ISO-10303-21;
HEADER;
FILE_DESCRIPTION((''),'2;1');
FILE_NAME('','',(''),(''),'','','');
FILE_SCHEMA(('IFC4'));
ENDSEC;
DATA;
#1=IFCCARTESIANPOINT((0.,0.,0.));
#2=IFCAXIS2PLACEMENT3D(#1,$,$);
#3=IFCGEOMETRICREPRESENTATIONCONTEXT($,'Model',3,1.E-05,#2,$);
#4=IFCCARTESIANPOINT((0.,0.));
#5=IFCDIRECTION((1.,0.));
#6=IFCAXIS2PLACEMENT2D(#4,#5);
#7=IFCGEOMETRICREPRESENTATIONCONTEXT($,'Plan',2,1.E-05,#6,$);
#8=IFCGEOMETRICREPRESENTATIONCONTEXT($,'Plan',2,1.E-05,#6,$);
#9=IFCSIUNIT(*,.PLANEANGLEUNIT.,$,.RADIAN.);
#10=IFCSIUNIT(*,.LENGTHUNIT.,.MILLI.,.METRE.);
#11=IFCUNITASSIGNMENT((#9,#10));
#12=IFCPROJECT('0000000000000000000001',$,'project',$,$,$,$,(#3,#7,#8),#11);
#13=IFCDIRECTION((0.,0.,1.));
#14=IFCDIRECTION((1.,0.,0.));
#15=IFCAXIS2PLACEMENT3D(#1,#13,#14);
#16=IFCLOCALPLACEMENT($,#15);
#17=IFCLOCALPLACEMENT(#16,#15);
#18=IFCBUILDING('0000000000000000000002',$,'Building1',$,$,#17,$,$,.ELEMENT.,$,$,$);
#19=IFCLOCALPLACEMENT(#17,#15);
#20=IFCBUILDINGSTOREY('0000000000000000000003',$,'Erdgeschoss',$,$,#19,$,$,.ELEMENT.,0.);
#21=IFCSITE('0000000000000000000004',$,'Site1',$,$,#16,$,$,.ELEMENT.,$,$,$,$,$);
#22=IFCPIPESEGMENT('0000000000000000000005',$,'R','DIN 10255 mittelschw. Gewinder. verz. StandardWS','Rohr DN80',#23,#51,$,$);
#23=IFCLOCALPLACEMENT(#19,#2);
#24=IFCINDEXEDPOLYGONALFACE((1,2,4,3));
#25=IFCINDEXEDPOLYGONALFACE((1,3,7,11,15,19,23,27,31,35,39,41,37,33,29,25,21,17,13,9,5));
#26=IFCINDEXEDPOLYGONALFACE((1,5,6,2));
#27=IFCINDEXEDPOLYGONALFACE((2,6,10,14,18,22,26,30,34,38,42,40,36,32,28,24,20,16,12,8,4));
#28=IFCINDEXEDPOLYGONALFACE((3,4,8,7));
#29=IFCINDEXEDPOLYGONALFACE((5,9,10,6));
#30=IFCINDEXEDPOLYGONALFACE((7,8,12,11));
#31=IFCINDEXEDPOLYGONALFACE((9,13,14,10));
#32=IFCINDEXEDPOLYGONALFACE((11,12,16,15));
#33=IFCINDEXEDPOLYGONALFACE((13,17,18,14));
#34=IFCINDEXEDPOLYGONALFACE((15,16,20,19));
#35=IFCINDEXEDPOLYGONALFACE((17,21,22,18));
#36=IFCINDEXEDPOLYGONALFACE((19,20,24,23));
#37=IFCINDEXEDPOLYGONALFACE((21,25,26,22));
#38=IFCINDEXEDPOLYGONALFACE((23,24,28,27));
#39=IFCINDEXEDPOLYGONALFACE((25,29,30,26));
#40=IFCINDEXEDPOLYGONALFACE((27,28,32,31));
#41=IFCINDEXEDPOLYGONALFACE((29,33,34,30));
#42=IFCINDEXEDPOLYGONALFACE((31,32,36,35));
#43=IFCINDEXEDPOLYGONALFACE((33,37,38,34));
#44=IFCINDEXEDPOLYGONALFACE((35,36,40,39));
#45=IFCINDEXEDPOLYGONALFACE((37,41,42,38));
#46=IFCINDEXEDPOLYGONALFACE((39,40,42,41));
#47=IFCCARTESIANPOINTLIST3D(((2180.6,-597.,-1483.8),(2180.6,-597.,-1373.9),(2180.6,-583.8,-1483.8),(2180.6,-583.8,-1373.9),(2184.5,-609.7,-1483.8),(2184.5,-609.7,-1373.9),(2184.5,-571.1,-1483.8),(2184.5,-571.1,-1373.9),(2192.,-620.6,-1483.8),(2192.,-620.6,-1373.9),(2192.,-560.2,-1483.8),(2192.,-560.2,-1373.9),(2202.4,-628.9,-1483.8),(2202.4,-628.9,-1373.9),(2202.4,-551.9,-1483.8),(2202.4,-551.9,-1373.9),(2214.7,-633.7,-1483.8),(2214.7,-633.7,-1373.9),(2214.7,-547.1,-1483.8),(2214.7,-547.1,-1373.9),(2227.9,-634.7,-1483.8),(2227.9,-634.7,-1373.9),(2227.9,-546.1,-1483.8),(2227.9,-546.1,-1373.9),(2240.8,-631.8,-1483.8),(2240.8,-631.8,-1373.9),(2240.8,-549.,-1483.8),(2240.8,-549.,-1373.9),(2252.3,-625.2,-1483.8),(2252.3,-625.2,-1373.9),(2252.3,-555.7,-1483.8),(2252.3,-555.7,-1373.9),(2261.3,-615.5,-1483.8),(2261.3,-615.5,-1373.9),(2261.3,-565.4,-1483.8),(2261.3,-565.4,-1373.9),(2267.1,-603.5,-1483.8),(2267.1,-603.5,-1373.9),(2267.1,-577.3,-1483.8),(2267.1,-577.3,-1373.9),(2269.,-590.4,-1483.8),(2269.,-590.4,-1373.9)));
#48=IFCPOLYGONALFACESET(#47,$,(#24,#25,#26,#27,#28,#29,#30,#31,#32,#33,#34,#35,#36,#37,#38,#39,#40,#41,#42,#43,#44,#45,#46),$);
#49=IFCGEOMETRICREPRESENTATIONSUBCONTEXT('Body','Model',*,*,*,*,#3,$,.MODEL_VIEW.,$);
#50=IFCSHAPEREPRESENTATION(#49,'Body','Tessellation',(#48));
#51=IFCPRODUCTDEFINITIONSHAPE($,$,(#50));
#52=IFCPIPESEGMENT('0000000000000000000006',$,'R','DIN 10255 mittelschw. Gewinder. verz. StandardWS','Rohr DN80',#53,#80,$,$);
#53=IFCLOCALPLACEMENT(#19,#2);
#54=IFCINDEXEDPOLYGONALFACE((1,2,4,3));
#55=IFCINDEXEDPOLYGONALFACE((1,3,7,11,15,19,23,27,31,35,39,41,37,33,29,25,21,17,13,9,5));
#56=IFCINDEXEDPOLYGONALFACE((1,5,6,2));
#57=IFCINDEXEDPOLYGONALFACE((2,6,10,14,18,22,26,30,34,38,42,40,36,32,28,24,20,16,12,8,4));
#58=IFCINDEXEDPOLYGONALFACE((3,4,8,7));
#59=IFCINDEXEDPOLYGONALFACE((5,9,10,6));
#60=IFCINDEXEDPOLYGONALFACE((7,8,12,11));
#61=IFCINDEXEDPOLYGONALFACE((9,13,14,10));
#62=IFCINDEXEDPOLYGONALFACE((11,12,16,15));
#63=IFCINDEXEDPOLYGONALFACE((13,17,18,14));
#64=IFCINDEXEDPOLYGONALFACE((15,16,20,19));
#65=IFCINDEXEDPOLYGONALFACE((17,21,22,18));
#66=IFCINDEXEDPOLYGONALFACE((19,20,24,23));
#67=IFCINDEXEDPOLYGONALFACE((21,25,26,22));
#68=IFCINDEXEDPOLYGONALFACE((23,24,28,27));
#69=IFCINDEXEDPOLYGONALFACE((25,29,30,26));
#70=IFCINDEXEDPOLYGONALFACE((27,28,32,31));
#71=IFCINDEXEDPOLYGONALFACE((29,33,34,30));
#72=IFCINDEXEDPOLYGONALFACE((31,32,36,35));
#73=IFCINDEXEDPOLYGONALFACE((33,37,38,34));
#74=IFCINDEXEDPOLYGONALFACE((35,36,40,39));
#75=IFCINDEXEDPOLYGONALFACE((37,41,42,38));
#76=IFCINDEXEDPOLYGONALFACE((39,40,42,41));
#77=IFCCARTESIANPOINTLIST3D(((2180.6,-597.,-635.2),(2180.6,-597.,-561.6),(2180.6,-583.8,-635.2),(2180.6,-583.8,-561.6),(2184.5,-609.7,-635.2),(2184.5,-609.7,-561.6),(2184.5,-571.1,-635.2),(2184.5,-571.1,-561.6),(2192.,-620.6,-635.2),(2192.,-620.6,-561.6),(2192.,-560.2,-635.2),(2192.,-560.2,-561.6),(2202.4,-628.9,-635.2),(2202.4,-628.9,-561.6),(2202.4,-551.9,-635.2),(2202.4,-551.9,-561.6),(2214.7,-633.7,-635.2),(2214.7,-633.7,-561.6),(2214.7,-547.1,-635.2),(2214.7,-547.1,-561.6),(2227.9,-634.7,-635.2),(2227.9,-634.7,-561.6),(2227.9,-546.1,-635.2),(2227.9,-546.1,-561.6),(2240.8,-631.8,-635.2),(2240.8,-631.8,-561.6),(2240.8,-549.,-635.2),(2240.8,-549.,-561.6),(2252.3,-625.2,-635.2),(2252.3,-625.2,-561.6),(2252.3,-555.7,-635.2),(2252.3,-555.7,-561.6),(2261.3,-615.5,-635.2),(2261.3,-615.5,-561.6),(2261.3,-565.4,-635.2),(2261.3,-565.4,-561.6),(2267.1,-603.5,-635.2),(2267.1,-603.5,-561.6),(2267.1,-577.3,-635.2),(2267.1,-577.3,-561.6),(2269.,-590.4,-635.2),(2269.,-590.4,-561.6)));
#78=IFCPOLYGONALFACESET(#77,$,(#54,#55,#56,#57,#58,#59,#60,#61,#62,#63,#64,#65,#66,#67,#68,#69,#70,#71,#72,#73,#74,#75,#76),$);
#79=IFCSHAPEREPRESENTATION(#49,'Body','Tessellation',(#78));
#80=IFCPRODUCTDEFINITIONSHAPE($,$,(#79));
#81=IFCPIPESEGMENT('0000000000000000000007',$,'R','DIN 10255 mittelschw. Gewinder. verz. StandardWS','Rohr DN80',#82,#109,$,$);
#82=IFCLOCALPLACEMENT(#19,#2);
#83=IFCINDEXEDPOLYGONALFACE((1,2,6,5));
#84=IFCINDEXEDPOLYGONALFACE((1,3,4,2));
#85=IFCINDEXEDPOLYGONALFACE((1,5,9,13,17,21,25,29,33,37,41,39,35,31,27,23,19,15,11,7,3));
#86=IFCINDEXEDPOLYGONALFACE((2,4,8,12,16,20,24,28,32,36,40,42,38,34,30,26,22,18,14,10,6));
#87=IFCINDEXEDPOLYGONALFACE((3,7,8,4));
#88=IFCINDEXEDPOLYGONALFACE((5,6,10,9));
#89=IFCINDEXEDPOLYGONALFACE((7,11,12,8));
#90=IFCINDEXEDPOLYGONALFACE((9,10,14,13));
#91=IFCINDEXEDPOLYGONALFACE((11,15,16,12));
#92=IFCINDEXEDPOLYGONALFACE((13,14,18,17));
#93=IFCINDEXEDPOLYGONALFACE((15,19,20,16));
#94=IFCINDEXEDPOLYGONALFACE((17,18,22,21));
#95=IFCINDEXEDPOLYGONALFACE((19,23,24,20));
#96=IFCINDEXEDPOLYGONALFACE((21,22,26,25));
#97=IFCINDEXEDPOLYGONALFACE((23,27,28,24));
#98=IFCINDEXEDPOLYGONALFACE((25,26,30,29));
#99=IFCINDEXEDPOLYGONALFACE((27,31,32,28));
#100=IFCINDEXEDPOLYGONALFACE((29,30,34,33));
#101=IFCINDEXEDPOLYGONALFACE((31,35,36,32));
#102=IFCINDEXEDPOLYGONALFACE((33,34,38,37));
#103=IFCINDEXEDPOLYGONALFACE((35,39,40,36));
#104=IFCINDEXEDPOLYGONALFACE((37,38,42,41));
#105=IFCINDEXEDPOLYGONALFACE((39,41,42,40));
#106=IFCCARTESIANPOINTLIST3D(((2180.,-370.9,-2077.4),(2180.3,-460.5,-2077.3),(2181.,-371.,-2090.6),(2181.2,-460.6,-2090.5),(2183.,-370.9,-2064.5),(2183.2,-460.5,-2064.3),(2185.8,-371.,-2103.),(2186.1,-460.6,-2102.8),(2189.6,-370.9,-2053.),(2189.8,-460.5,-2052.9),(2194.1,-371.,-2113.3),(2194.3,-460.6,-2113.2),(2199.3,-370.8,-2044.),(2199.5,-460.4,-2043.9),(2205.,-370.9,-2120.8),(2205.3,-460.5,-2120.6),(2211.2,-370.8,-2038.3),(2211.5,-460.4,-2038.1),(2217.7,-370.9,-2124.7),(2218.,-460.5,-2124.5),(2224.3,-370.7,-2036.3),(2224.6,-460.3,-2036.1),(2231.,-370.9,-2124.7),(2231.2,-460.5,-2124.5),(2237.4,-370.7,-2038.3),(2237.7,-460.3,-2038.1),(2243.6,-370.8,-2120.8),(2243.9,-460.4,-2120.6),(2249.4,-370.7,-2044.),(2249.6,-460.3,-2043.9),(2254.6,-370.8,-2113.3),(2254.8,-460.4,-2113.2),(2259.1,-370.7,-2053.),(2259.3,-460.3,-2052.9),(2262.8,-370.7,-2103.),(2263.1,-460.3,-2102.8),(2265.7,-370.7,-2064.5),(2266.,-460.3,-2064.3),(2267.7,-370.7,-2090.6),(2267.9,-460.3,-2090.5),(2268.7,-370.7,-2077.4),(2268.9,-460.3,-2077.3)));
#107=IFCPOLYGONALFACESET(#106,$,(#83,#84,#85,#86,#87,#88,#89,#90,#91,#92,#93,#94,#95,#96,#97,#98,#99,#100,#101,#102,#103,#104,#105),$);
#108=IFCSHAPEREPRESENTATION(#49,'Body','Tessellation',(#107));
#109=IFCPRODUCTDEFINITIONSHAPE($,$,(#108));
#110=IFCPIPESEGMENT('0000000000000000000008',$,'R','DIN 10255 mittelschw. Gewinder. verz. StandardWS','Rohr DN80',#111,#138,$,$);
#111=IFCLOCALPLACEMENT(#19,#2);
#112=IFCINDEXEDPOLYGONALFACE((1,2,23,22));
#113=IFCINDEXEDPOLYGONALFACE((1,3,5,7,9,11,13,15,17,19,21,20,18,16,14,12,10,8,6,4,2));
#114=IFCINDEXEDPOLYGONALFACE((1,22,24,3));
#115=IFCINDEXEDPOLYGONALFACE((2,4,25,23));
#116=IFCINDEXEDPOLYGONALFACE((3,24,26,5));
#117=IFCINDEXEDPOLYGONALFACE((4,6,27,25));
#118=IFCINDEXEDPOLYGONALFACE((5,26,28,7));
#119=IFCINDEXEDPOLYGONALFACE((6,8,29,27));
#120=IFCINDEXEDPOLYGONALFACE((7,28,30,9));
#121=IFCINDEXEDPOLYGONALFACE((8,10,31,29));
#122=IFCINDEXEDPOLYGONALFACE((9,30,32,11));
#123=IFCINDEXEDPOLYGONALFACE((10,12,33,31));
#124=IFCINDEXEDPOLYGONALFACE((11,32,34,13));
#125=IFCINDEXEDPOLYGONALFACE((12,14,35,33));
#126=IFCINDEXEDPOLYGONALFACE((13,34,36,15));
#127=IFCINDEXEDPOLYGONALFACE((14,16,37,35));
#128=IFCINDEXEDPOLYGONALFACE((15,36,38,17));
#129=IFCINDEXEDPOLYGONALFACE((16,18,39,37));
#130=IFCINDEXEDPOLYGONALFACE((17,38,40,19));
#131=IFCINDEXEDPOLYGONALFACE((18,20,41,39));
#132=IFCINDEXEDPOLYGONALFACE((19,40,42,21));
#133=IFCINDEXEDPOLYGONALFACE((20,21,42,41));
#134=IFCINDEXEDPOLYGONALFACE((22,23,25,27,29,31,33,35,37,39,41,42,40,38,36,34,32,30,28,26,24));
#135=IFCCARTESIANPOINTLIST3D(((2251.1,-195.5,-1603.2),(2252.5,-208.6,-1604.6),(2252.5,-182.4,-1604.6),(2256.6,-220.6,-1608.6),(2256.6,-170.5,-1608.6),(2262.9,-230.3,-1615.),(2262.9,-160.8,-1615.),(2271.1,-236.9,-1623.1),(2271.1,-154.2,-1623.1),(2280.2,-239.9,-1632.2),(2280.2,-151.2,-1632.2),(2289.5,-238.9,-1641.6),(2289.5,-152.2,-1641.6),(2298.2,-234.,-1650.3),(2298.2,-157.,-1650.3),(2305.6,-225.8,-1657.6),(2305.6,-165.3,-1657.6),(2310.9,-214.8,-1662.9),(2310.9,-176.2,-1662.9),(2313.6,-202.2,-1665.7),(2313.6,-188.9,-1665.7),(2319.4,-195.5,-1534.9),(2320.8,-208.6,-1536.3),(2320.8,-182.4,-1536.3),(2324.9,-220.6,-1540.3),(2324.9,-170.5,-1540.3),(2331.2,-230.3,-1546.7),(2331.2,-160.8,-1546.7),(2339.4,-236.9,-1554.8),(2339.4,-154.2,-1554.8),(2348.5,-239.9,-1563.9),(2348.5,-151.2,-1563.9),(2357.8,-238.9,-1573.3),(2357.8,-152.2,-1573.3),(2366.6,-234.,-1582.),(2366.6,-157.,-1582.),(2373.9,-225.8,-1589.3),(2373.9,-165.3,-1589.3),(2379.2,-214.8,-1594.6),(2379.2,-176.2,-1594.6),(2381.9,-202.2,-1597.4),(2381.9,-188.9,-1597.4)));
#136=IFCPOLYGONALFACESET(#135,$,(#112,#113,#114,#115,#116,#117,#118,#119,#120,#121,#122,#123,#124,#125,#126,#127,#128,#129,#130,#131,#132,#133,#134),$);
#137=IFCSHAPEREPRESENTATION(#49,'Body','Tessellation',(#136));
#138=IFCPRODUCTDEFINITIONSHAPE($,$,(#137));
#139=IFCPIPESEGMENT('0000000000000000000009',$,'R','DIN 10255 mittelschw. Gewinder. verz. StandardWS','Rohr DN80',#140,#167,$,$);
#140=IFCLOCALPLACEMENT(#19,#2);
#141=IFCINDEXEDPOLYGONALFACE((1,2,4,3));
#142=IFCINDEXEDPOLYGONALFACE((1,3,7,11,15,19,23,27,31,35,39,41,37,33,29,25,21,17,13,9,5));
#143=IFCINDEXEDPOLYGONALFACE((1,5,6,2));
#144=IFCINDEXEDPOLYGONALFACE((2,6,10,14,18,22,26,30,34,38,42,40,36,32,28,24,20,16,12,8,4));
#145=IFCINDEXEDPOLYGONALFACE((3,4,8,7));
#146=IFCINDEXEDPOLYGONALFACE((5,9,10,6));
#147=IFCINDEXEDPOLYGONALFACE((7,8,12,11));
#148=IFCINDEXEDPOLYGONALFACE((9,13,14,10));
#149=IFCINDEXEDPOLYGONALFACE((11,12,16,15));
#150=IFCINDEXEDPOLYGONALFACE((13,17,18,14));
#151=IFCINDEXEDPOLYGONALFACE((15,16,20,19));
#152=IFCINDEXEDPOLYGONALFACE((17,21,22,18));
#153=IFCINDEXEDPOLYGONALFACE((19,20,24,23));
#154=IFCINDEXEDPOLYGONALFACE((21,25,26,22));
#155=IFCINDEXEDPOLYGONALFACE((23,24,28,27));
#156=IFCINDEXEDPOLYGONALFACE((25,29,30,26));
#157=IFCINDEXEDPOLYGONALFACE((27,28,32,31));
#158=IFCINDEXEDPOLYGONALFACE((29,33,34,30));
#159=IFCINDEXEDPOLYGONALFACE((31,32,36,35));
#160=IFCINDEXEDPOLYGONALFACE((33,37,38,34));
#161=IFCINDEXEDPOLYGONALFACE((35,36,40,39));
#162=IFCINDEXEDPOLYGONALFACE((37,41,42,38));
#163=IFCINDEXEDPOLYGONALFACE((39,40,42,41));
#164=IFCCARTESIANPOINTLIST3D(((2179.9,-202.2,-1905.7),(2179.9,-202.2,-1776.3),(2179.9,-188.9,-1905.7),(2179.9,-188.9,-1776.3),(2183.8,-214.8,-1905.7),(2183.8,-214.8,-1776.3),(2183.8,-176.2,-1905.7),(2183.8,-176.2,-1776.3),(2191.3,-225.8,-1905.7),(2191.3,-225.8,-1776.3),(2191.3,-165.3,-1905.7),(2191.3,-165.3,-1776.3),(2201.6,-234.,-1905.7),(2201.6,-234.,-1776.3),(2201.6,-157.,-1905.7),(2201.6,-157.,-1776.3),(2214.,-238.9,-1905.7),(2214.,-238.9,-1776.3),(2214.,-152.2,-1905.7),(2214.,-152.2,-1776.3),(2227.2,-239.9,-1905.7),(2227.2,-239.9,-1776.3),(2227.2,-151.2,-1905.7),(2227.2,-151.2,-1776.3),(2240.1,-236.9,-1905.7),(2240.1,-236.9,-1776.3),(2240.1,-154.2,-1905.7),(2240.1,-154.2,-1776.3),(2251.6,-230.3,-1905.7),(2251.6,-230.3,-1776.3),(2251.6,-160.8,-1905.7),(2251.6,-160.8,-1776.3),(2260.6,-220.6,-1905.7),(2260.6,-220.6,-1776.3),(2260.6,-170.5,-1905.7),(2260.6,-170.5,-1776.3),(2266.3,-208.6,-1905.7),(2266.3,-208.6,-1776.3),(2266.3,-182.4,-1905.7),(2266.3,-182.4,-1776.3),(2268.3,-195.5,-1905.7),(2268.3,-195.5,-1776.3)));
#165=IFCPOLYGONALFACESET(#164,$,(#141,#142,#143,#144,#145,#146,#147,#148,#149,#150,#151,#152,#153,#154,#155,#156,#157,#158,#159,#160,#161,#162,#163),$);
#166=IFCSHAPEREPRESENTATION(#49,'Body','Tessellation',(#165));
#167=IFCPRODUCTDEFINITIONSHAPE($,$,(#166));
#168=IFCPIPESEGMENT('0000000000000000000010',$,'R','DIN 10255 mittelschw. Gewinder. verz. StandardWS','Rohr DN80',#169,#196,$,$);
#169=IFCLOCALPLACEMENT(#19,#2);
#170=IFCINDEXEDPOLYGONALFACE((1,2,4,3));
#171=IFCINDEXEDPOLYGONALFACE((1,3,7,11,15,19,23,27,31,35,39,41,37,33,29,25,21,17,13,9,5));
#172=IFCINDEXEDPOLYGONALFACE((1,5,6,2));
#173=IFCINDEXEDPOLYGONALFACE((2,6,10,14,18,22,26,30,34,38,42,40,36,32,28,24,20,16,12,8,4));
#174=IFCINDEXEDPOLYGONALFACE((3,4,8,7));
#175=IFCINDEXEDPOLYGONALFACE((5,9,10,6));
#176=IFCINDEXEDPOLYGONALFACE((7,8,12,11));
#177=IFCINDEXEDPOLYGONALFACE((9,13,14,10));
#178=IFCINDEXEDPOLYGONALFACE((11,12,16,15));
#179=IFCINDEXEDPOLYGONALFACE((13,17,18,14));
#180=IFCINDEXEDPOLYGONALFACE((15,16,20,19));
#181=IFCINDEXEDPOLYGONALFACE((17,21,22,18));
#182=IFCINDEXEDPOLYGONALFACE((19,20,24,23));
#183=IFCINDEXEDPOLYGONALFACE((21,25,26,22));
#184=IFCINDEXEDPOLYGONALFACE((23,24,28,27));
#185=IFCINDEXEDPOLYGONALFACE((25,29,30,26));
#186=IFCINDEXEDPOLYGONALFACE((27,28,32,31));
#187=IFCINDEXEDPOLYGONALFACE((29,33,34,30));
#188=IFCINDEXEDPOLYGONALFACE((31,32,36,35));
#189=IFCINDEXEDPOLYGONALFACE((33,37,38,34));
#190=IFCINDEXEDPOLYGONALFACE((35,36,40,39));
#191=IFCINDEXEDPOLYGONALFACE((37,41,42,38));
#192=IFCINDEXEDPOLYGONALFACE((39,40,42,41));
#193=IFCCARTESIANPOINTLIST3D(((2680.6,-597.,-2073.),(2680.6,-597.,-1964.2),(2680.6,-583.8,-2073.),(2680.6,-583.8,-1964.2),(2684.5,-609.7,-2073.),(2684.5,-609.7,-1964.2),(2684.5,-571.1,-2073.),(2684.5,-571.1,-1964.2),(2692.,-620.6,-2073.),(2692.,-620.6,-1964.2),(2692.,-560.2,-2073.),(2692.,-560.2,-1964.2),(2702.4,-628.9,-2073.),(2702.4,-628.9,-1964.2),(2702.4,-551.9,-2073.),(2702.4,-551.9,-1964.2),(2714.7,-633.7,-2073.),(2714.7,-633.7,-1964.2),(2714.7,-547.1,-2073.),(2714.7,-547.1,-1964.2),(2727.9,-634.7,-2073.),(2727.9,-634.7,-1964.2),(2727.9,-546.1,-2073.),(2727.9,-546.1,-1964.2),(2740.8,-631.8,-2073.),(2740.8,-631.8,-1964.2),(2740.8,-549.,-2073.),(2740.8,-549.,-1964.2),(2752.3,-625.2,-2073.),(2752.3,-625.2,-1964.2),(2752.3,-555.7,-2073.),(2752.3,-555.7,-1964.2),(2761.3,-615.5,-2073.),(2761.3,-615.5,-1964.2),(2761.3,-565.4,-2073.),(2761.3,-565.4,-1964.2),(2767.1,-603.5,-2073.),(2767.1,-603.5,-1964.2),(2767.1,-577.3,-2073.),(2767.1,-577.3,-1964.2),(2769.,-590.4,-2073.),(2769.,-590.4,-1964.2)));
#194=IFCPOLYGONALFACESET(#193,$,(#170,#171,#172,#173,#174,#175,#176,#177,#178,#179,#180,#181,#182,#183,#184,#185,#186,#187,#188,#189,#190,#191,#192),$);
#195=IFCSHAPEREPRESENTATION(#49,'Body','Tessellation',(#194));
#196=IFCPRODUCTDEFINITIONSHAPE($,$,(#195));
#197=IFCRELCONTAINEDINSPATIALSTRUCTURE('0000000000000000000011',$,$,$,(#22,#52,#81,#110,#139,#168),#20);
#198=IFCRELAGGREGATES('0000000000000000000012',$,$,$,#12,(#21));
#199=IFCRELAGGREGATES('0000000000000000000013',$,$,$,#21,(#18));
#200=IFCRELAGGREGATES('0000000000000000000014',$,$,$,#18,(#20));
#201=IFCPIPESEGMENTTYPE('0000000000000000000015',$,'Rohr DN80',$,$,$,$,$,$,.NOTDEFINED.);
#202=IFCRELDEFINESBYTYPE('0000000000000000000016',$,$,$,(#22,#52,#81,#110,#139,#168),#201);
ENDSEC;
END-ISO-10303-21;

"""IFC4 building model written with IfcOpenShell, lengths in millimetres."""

from ifc_helpers import new_model, si_unit, frame, origin, origin_with_axes, origin_2d_with_axis, place, context, subcontext, project, spatial, circle, extrude, type_object, element, save


model = new_model("IFC4")

# Units and contexts
model_context = context("Model", 3, precision=1e-05, world=origin())
plan_context_1 = context("Plan", 2, precision=1e-05, world=origin_2d_with_axis())
plan_context_2 = context("Plan", 2, precision=1e-05, world=origin_2d_with_axis())
body_context = subcontext(model_context, "Body", "Model", "MODEL_VIEW")
ifc_project = project(units=[si_unit("PLANEANGLEUNIT", "RADIAN"), si_unit("LENGTHUNIT", "METRE", prefix="MILLI")], contexts=[model_context, plan_context_1, plan_context_2])

# Site, building, storey
site_placement = place(None, origin_with_axes())
site = spatial("IfcSite", under=ifc_project, at=site_placement, Name="Site1", CompositionType="ELEMENT")
building_placement = place(site_placement, origin_with_axes())
building = spatial("IfcBuilding", under=site, at=building_placement, Name="Building1", CompositionType="ELEMENT")
storey_placement = place(building_placement, origin_with_axes())
storey = spatial("IfcBuildingStorey", under=building, at=storey_placement, Name="Erdgeschoss", CompositionType="ELEMENT", Elevation=0.0)

# Pipe segments
pipe_segment_type_1 = type_object("IfcPipeSegmentType", Name="Rohr DN80", PredefinedType="NOTDEFINED")
pipe_segment_1_placement = place(storey_placement, frame((2224.6, -590.6, -1428.8), z_axis=(0.0, 0.0, 1.0), x_axis=(1.0, 0.0, 0.0)))
element("IfcPipeSegment", 1, at=pipe_segment_1_placement, inside=storey, type_object=pipe_segment_type_1, Name="R", Description="DIN 10255 mittelschw. Gewinder. verz. StandardWS", ObjectType="Rohr DN80", context=body_context, shape_type="SolidModel", body=[
    extrude(circle(Radius=44.5, at=origin_2d_with_axis()), frame((0.0, 0.1, -55.0), z_axis=(0.0, 0.0, 1.0), x_axis=(1.0, 0.0, 0.0)), (0.0, 0.0, 1.0), 109.9),
])
pipe_segment_2_placement = place(storey_placement, frame((2224.6, -590.6, -598.4), z_axis=(0.0, 0.0, 1.0), x_axis=(1.0, 0.0, 0.0)))
element("IfcPipeSegment", 2, at=pipe_segment_2_placement, inside=storey, type_object=pipe_segment_type_1, Name="R", Description="DIN 10255 mittelschw. Gewinder. verz. StandardWS", ObjectType="Rohr DN80", context=body_context, shape_type="SolidModel", body=[
    extrude(circle(Radius=44.5, at=origin_2d_with_axis()), frame((0.0, 0.1, -36.8), z_axis=(0.0, 0.0, 1.0), x_axis=(1.0, 0.0, 0.0)), (0.0, 0.0, 1.0), 73.6),
])
pipe_segment_3_placement = place(storey_placement, frame((2224.6, -415.6, -2080.7), z_axis=(0.0, 0.0, 1.0), x_axis=(1.0, 0.0, 0.0)))
element("IfcPipeSegment", 3, at=pipe_segment_3_placement, inside=storey, type_object=pipe_segment_type_1, Name="R", Description="DIN 10255 mittelschw. Gewinder. verz. StandardWS", ObjectType="Rohr DN80", context=body_context, shape_type="SolidModel", body=[
    extrude(circle(Radius=44.5, at=origin_2d_with_axis()), frame((-0.3, 44.8, -0.1), z_axis=(0.002779, -0.999995, 0.001637), x_axis=(0.0, 0.0, 1.0)), (0.0, 0.0, 1.0), 89.6),
])
pipe_segment_4_placement = place(storey_placement, frame((2316.7, -195.7, -1600.4), z_axis=(0.0, 0.0, 1.0), x_axis=(1.0, 0.0, 0.0)))
element("IfcPipeSegment", 4, at=pipe_segment_4_placement, inside=storey, type_object=pipe_segment_type_1, Name="R", Description="DIN 10255 mittelschw. Gewinder. verz. StandardWS", ObjectType="Rohr DN80", context=body_context, shape_type="SolidModel", body=[
    extrude(circle(Radius=44.5, at=origin_2d_with_axis()), frame((34.2, 0.2, 34.2), z_axis=(-0.707107, 0.0, -0.707107), x_axis=(0.0, 0.0, 1.0)), (0.0, 0.0, 1.0), 96.6),
])
pipe_segment_5_placement = place(storey_placement, frame((2223.8, -195.7, -1841.0), z_axis=(0.0, 0.0, 1.0), x_axis=(1.0, 0.0, 0.0)))
element("IfcPipeSegment", 5, at=pipe_segment_5_placement, inside=storey, type_object=pipe_segment_type_1, Name="R", Description="DIN 10255 mittelschw. Gewinder. verz. StandardWS", ObjectType="Rohr DN80", context=body_context, shape_type="SolidModel", body=[
    extrude(circle(Radius=44.5, at=origin_2d_with_axis()), frame((0.0, 0.1, -64.7), z_axis=(0.0, 0.0, 1.0), x_axis=(1.0, 0.0, 0.0)), (0.0, 0.0, 1.0), 129.4),
])
pipe_segment_6_placement = place(storey_placement, frame((2724.6, -590.6, -2018.6), z_axis=(0.0, 0.0, 1.0), x_axis=(1.0, 0.0, 0.0)))
element("IfcPipeSegment", 6, at=pipe_segment_6_placement, inside=storey, type_object=pipe_segment_type_1, Name="R", Description="DIN 10255 mittelschw. Gewinder. verz. StandardWS", ObjectType="Rohr DN80", context=body_context, shape_type="SolidModel", body=[
    extrude(circle(Radius=44.5, at=origin_2d_with_axis()), frame((0.0, 0.1, -54.4), z_axis=(0.0, 0.0, 1.0), x_axis=(1.0, 0.0, 0.0)), (0.0, 0.0, 1.0), 108.8),
])

save(model, "model.ifc")
